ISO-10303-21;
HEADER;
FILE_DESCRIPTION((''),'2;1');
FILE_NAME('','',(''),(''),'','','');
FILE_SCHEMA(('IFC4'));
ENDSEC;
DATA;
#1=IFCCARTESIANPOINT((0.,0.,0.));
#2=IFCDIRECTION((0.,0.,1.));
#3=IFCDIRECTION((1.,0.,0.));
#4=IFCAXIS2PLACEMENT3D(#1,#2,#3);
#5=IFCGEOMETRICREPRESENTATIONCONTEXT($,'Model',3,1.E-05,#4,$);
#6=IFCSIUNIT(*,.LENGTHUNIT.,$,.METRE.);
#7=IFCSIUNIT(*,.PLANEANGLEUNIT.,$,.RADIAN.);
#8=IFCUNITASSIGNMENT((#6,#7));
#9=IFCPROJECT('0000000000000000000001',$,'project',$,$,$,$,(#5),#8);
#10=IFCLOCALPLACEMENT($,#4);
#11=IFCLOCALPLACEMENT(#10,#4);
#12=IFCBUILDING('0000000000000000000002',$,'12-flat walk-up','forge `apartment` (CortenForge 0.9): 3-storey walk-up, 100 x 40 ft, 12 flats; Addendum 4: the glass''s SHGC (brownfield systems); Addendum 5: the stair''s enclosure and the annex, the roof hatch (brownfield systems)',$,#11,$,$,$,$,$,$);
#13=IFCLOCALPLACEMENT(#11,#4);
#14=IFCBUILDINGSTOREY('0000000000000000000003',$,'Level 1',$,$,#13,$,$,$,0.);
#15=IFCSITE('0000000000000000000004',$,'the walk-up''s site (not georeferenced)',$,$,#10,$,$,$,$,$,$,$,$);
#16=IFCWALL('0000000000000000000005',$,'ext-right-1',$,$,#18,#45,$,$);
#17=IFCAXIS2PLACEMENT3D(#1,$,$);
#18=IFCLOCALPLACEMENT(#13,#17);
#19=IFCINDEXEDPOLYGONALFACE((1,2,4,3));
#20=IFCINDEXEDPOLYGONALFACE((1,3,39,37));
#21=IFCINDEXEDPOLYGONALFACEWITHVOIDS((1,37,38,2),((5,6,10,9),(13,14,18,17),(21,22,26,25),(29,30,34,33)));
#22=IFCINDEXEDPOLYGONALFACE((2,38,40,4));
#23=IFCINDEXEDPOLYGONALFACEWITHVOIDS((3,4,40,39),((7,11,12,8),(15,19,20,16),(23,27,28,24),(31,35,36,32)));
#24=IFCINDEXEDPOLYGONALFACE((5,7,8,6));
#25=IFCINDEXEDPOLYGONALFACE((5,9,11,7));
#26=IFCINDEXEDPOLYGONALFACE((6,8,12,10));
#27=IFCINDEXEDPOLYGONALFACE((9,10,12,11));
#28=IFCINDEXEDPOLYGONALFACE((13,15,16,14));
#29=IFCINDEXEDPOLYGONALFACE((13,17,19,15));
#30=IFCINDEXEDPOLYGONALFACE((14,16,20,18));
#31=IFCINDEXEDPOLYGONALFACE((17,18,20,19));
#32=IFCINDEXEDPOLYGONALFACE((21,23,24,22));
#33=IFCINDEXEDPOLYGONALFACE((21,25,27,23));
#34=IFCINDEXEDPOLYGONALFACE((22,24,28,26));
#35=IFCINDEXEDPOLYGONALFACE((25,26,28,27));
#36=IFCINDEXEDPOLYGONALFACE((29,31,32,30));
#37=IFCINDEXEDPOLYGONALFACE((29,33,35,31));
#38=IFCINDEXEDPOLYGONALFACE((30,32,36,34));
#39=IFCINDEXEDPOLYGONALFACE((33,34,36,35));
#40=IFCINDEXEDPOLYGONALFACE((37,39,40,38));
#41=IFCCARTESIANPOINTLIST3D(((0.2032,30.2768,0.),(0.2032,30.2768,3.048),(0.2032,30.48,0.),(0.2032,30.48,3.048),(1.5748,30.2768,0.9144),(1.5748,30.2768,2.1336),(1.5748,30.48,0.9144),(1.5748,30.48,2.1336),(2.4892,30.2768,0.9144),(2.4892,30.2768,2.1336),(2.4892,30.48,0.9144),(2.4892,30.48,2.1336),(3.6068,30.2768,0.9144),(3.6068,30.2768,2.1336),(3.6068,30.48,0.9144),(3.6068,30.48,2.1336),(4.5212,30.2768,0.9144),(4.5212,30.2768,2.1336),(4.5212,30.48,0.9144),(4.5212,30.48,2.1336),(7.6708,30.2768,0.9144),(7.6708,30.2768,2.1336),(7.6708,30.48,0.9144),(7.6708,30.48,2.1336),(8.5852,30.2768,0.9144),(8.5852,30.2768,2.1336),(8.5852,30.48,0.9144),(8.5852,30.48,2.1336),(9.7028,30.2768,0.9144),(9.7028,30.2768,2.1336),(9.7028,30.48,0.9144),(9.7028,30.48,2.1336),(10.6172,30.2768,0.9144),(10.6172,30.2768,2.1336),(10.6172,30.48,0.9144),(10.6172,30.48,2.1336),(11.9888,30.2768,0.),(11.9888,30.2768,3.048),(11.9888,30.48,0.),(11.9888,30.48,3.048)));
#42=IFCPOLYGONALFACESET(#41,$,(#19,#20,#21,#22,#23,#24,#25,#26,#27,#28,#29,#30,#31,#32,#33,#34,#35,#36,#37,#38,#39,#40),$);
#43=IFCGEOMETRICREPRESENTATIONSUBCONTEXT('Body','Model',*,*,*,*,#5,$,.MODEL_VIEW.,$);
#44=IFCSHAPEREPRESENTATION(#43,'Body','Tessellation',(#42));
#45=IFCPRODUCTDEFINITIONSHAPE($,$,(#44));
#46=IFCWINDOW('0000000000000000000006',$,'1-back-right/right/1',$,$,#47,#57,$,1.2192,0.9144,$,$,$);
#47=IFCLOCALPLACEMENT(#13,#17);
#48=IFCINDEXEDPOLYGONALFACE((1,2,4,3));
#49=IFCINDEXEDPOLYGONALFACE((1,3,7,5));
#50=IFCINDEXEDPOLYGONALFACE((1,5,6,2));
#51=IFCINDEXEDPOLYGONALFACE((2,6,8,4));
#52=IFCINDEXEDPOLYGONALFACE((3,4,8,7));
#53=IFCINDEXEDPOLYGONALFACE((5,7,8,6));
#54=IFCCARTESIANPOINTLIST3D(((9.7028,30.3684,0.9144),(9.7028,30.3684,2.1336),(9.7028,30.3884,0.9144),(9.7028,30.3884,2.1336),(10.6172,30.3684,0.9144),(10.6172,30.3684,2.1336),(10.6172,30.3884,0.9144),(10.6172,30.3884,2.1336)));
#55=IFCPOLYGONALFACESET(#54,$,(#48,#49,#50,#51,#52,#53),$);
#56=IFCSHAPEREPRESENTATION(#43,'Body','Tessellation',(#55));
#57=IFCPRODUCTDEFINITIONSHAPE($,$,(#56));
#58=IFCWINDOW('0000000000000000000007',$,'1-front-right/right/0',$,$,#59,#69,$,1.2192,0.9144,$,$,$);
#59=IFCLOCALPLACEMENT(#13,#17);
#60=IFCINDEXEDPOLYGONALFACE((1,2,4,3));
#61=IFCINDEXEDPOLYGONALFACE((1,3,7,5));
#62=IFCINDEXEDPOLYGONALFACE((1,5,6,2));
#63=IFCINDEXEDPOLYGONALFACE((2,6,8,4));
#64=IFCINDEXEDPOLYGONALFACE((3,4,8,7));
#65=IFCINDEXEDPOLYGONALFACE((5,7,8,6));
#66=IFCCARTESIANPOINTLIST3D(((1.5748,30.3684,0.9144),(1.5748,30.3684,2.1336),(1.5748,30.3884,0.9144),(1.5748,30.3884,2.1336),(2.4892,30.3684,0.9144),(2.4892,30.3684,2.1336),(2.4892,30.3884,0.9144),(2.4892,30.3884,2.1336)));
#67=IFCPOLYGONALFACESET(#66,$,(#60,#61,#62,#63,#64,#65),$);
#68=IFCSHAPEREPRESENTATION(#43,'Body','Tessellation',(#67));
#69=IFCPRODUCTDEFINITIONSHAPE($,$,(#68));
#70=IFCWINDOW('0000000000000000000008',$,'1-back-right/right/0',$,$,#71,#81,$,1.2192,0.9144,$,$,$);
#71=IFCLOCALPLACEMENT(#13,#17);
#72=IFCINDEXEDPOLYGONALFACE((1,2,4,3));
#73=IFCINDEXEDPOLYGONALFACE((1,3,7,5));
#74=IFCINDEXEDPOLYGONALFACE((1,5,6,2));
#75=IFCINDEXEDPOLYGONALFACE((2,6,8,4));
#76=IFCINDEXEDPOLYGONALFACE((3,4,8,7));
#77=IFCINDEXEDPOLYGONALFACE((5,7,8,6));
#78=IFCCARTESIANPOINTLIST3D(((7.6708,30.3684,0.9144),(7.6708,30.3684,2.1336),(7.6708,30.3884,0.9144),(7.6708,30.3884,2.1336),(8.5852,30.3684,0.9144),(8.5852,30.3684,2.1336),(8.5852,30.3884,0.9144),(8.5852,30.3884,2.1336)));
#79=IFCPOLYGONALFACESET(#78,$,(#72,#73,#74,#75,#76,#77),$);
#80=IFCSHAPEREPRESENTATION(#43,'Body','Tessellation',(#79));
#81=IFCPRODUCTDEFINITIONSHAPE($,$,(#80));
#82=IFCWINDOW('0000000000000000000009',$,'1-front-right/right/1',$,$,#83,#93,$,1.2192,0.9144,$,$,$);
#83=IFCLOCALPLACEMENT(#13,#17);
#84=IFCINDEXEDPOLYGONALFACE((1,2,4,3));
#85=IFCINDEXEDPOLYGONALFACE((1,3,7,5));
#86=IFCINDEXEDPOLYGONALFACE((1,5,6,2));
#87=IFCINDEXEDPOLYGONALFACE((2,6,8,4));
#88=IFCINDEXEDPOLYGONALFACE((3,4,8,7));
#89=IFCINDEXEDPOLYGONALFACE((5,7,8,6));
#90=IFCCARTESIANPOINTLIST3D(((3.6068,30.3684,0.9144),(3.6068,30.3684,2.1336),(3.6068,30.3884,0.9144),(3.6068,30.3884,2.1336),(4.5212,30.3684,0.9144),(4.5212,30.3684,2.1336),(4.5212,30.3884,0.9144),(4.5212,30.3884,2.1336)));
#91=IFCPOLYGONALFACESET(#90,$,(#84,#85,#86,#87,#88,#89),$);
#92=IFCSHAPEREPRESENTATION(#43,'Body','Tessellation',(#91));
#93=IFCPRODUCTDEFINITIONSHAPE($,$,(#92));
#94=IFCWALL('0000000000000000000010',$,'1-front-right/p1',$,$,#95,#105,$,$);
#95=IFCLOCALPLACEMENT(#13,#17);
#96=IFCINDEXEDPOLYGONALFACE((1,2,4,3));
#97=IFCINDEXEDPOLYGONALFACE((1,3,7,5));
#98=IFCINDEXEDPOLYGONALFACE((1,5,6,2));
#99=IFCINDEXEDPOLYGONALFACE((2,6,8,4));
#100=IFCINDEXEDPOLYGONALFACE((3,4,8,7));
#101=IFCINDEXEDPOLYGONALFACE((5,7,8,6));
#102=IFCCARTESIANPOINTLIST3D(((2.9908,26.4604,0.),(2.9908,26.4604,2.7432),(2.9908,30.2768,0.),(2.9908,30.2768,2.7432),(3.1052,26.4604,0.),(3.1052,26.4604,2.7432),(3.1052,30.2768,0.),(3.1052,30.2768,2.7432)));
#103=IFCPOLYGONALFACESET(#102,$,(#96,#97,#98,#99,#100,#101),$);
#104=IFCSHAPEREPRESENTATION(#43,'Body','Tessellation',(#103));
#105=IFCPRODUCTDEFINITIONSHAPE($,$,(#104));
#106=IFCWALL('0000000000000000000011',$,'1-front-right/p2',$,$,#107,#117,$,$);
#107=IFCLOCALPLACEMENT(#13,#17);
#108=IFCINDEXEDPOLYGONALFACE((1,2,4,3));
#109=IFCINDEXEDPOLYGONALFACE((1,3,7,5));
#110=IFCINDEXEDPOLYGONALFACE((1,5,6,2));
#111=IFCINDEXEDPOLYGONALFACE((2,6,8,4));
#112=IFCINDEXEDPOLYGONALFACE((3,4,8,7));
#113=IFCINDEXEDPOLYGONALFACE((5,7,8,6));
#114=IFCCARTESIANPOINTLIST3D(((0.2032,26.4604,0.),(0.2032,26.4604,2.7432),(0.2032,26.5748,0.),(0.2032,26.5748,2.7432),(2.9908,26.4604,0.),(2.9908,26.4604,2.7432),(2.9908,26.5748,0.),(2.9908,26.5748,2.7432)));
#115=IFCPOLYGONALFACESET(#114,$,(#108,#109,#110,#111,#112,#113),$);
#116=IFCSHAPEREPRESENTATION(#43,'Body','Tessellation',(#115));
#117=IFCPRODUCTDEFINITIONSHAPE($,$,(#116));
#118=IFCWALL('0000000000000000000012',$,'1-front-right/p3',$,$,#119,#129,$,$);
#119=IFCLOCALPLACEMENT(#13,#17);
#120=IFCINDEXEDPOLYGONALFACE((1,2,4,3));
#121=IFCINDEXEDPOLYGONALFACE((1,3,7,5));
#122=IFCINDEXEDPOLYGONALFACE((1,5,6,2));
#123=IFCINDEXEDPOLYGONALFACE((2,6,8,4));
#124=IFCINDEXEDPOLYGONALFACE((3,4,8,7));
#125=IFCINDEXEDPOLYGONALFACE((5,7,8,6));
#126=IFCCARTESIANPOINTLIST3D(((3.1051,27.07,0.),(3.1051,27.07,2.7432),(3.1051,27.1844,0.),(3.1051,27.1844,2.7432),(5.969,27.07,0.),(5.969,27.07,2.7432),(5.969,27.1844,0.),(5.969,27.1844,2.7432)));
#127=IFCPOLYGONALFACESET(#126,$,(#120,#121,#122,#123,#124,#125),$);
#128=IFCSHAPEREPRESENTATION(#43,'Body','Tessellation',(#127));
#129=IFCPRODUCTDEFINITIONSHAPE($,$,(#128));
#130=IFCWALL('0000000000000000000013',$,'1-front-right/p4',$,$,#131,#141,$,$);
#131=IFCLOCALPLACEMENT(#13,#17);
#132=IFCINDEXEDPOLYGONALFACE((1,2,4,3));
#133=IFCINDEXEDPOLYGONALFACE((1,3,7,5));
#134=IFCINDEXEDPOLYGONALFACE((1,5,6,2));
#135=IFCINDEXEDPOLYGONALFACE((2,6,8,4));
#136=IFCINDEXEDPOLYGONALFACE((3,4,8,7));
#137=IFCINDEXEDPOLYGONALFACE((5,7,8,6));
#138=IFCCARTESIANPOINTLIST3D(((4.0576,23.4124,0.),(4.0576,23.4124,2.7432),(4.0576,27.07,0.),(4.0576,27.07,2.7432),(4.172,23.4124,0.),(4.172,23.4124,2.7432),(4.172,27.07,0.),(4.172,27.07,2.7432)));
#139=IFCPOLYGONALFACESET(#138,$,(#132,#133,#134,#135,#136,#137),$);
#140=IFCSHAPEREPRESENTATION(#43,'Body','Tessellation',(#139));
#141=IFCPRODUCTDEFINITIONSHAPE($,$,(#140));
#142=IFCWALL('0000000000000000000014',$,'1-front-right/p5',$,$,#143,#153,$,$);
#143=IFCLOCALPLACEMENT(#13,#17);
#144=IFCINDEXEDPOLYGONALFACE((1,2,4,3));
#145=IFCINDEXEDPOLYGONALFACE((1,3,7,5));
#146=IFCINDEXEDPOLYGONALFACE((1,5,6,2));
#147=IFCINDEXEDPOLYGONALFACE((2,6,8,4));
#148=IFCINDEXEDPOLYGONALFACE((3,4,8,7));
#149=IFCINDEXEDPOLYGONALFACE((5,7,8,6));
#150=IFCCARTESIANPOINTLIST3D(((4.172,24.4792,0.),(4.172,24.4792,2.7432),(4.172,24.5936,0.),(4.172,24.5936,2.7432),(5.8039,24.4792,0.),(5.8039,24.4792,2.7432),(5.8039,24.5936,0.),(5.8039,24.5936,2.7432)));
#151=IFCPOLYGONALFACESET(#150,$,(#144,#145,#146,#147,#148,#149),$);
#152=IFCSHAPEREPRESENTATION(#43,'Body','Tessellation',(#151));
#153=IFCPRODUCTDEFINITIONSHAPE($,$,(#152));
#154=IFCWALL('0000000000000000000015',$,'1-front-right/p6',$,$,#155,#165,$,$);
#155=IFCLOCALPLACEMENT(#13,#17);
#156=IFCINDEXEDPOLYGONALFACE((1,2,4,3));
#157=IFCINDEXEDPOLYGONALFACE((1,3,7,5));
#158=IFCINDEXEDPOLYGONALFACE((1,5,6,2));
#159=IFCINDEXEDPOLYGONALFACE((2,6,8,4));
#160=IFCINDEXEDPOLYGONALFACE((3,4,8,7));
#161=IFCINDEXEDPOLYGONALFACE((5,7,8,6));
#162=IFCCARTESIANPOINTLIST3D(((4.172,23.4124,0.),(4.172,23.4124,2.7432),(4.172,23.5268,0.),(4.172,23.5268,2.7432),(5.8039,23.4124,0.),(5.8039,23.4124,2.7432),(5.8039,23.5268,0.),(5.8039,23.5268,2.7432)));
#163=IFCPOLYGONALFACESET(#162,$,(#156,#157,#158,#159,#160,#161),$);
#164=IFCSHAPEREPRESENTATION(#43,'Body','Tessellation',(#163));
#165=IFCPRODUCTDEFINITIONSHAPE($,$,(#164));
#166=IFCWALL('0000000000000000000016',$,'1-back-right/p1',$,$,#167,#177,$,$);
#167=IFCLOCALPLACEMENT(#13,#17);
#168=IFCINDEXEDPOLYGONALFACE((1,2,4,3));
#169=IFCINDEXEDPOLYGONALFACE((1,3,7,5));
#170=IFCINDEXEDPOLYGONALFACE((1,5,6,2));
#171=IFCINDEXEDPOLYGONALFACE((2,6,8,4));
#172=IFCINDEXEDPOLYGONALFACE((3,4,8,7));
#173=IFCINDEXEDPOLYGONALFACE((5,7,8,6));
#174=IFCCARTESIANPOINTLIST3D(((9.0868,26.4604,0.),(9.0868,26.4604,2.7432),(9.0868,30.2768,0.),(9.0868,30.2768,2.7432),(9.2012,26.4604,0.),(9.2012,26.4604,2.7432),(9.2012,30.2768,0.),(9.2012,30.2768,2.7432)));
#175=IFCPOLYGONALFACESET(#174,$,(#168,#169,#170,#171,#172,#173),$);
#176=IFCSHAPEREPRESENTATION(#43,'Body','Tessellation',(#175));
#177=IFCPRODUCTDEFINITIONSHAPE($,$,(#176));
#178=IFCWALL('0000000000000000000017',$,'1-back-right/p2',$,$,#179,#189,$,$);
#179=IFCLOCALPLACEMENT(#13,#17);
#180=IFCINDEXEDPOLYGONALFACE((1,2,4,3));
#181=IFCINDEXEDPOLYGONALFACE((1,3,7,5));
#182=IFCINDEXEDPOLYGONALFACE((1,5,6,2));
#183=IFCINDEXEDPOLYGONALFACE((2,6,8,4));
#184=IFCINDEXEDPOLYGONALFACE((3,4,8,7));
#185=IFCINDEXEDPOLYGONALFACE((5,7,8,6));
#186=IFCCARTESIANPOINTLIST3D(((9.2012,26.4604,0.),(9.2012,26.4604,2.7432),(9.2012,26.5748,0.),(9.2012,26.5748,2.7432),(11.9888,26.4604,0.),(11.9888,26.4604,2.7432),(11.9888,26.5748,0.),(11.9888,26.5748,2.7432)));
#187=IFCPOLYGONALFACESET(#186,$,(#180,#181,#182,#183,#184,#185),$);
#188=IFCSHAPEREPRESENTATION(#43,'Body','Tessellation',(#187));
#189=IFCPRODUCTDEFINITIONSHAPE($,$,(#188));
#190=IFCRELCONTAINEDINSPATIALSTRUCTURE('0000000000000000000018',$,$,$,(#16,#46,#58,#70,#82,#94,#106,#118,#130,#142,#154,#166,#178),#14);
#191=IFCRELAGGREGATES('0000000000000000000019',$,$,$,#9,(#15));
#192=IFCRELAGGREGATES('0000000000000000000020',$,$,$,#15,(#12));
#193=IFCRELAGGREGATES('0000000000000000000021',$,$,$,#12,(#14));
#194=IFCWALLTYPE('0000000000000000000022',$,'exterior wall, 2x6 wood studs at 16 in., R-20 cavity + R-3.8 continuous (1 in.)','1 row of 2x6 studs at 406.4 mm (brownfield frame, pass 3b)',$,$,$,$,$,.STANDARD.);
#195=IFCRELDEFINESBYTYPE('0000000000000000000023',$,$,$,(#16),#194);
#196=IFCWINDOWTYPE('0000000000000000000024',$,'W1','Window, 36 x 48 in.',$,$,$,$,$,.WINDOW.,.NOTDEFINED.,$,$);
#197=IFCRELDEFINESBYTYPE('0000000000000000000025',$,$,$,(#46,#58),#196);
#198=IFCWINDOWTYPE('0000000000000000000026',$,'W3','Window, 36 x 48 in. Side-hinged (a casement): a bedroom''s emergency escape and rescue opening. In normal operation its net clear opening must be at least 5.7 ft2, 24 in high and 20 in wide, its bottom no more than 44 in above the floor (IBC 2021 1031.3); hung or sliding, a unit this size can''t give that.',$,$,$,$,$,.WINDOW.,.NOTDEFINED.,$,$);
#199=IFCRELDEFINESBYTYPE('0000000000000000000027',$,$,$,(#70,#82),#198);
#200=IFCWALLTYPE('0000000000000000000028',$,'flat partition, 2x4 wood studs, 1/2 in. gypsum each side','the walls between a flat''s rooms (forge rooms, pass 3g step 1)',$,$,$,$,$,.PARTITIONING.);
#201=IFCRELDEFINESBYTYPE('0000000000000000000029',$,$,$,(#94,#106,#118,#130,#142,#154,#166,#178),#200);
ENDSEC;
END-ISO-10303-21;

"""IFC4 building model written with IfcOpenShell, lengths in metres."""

from ifc_helpers import new_model, si_unit, frame, frame_2d, origin, origin_with_axes, place, context, subcontext, project, spatial, rectangle, extrude, type_object, element, fill, save


model = new_model("IFC4")

# Units and contexts
model_context = context("Model", 3, precision=1e-05, world=origin_with_axes())
body_context = subcontext(model_context, "Body", "Model", "MODEL_VIEW")
ifc_project = project(units=[si_unit("LENGTHUNIT", "METRE"), si_unit("PLANEANGLEUNIT", "RADIAN")], contexts=[model_context])

# Site, building, storey
site_placement = place(None, origin_with_axes())
site = spatial("IfcSite", under=ifc_project, at=site_placement, Name="the walk-up's site (not georeferenced)")
building_placement = place(site_placement, origin_with_axes())
building = spatial("IfcBuilding", under=site, at=building_placement, Name="12-flat walk-up", Description="forge `apartment` (CortenForge 0.9): 3-storey walk-up, 100 x 40 ft, 12 flats; Addendum 4: the glass's SHGC (brownfield systems); Addendum 5: the stair's enclosure and the annex, the roof hatch (brownfield systems)")
storey_placement = place(building_placement, origin_with_axes())
storey = spatial("IfcBuildingStorey", under=building, at=storey_placement, Name="Level 1", Elevation=0.0)

# Wall, openings, windows
wall_type_1 = type_object("IfcWallType", Name="exterior wall, 2x6 wood studs at 16 in., R-20 cavity + R-3.8 continuous (1 in.)", Description="1 row of 2x6 studs at 406.4 mm (brownfield frame, pass 3b)", PredefinedType="STANDARD")
wall_1_placement = place(storey_placement, frame((0.2032, 30.2768, 0.0), z_axis=(0.0, 0.0, 1.0), x_axis=(1.0, 0.0, 0.0)))
wall_1 = element("IfcWall", 1, at=wall_1_placement, inside=storey, type_object=wall_type_1, Name="ext-right-1", context=body_context, shape_type="SweptSolid", body=[
    extrude(rectangle(XDim=11.7856, YDim=0.2032, at=frame_2d((5.8928, 0.1016))), origin(), (0.0, 0.0, 1.0), 3.048),
])
opening_1_placement = place(wall_1_placement, frame((8.382, 0.2032, 0.9144), z_axis=(0.0, 0.0, 1.0), x_axis=(-1.0, 0.0, 0.0)))
opening_1 = element("IfcOpeningElement", 2, at=opening_1_placement, cuts=wall_1, PredefinedType="OPENING", context=body_context, shape_type="SweptSolid", body=[
    extrude(rectangle(XDim=0.9144, YDim=0.2032, at=frame_2d((0.4572, 0.1016))), origin(), (0.0, 0.0, 1.0), 1.2192),
])
opening_2_placement = place(wall_1_placement, frame((10.414, 0.2032, 0.9144), z_axis=(0.0, 0.0, 1.0), x_axis=(-1.0, 0.0, 0.0)))
opening_2 = element("IfcOpeningElement", 3, at=opening_2_placement, cuts=wall_1, PredefinedType="OPENING", context=body_context, shape_type="SweptSolid", body=[
    extrude(rectangle(XDim=0.9144, YDim=0.2032, at=frame_2d((0.4572, 0.1016))), origin(), (0.0, 0.0, 1.0), 1.2192),
])
opening_3_placement = place(wall_1_placement, frame((2.286, 0.2032, 0.9144), z_axis=(0.0, 0.0, 1.0), x_axis=(-1.0, 0.0, 0.0)))
opening_3 = element("IfcOpeningElement", 4, at=opening_3_placement, cuts=wall_1, PredefinedType="OPENING", context=body_context, shape_type="SweptSolid", body=[
    extrude(rectangle(XDim=0.9144, YDim=0.2032, at=frame_2d((0.4572, 0.1016))), origin(), (0.0, 0.0, 1.0), 1.2192),
])
opening_4_placement = place(wall_1_placement, frame((4.318, 0.2032, 0.9144), z_axis=(0.0, 0.0, 1.0), x_axis=(-1.0, 0.0, 0.0)))
opening_4 = element("IfcOpeningElement", 5, at=opening_4_placement, cuts=wall_1, PredefinedType="OPENING", context=body_context, shape_type="SweptSolid", body=[
    extrude(rectangle(XDim=0.9144, YDim=0.2032, at=frame_2d((0.4572, 0.1016))), origin(), (0.0, 0.0, 1.0), 1.2192),
])
window_type_1 = type_object("IfcWindowType", Name="W1", Description="Window, 36 x 48 in.", PartitioningType="NOTDEFINED", PredefinedType="WINDOW")
window_1_placement = place(opening_2_placement, frame((0.0, 0.0916, 0.0), z_axis=(0.0, 0.0, 1.0), x_axis=(1.0, 0.0, 0.0)))
window_1 = element("IfcWindow", 6, at=window_1_placement, inside=storey, type_object=window_type_1, Name="1-back-right/right/1", OverallHeight=1.2192, OverallWidth=0.9144, context=body_context, shape_type="SweptSolid", body=[
    extrude(rectangle(XDim=0.9144, YDim=0.02, at=frame_2d((0.4572, 0.01))), origin(), (0.0, 0.0, 1.0), 1.2192),
])
fill(opening_2, window_1)
window_2_placement = place(opening_3_placement, frame((0.0, 0.0916, 0.0), z_axis=(0.0, 0.0, 1.0), x_axis=(1.0, 0.0, 0.0)))
window_2 = element("IfcWindow", 7, at=window_2_placement, inside=storey, type_object=window_type_1, Name="1-front-right/right/0", OverallHeight=1.2192, OverallWidth=0.9144, context=body_context, shape_type="SweptSolid", body=[
    extrude(rectangle(XDim=0.9144, YDim=0.02, at=frame_2d((0.4572, 0.01))), origin(), (0.0, 0.0, 1.0), 1.2192),
])
fill(opening_3, window_2)
window_type_2 = type_object("IfcWindowType", Name="W3", Description="Window, 36 x 48 in. Side-hinged (a casement): a bedroom's emergency escape and rescue opening. In normal operation its net clear opening must be at least 5.7 ft2, 24 in high and 20 in wide, its bottom no more than 44 in above the floor (IBC 2021 1031.3); hung or sliding, a unit this size can't give that.", PartitioningType="NOTDEFINED", PredefinedType="WINDOW")
window_3_placement = place(opening_1_placement, frame((0.0, 0.0916, 0.0), z_axis=(0.0, 0.0, 1.0), x_axis=(1.0, 0.0, 0.0)))
window_3 = element("IfcWindow", 8, at=window_3_placement, inside=storey, type_object=window_type_2, Name="1-back-right/right/0", OverallHeight=1.2192, OverallWidth=0.9144, context=body_context, shape_type="SweptSolid", body=[
    extrude(rectangle(XDim=0.9144, YDim=0.02, at=frame_2d((0.4572, 0.01))), origin(), (0.0, 0.0, 1.0), 1.2192),
])
fill(opening_1, window_3)
window_4_placement = place(opening_4_placement, frame((0.0, 0.0916, 0.0), z_axis=(0.0, 0.0, 1.0), x_axis=(1.0, 0.0, 0.0)))
window_4 = element("IfcWindow", 9, at=window_4_placement, inside=storey, type_object=window_type_2, Name="1-front-right/right/1", OverallHeight=1.2192, OverallWidth=0.9144, context=body_context, shape_type="SweptSolid", body=[
    extrude(rectangle(XDim=0.9144, YDim=0.02, at=frame_2d((0.4572, 0.01))), origin(), (0.0, 0.0, 1.0), 1.2192),
])
fill(opening_4, window_4)

# Walls
wall_type_2 = type_object("IfcWallType", Name="flat partition, 2x4 wood studs, 1/2 in. gypsum each side", Description="the walls between a flat's rooms (forge rooms, pass 3g step 1)", PredefinedType="PARTITIONING")
wall_2_placement = place(storey_placement, frame((2.9909, 26.4605, 0.0), z_axis=(0.0, 0.0, 1.0), x_axis=(1.0, 0.0, 0.0)))
element("IfcWall", 10, at=wall_2_placement, inside=storey, type_object=wall_type_2, Name="1-front-right/p1", context=body_context, shape_type="SweptSolid", body=[
    extrude(rectangle(XDim=0.1143, YDim=3.8163, at=frame_2d((0.0572, 1.9082))), origin(), (0.0, 0.0, 1.0), 2.7432),
])
wall_3_placement = place(storey_placement, frame((0.2032, 26.4605, 0.0), z_axis=(0.0, 0.0, 1.0), x_axis=(1.0, 0.0, 0.0)))
element("IfcWall", 11, at=wall_3_placement, inside=storey, type_object=wall_type_2, Name="1-front-right/p2", context=body_context, shape_type="SweptSolid", body=[
    extrude(rectangle(XDim=2.7877, YDim=0.1143, at=frame_2d((1.3938, 0.0572))), origin(), (0.0, 0.0, 1.0), 2.7432),
])
wall_4_placement = place(storey_placement, frame((3.1051, 27.07, 0.0), z_axis=(0.0, 0.0, 1.0), x_axis=(1.0, 0.0, 0.0)))
element("IfcWall", 12, at=wall_4_placement, inside=storey, type_object=wall_type_2, Name="1-front-right/p3", context=body_context, shape_type="SweptSolid", body=[
    extrude(rectangle(XDim=2.8639, YDim=0.1143, at=frame_2d((1.4319, 0.0572))), origin(), (0.0, 0.0, 1.0), 2.7432),
])
wall_5_placement = place(storey_placement, frame((4.0576, 23.4124, 0.0), z_axis=(0.0, 0.0, 1.0), x_axis=(1.0, 0.0, 0.0)))
element("IfcWall", 13, at=wall_5_placement, inside=storey, type_object=wall_type_2, Name="1-front-right/p4", context=body_context, shape_type="SweptSolid", body=[
    extrude(rectangle(XDim=0.1143, YDim=3.6576, at=frame_2d((0.0572, 1.8288))), origin(), (0.0, 0.0, 1.0), 2.7432),
])
for number, where, z_axis, x_axis, name in (
    (14, (4.1719, 24.4793, 0.0), (0.0, 0.0, 1.0), (1.0, 0.0, 0.0), "1-front-right/p5"),
    (15, (4.1719, 23.4124, 0.0), (0.0, 0.0, 1.0), (1.0, 0.0, 0.0), "1-front-right/p6"),
):
    element("IfcWall", number, at=place(storey_placement, frame(where, z_axis=z_axis, x_axis=x_axis)), inside=storey, type_object=wall_type_2, Name=name, context=body_context, shape_type="SweptSolid", body=[
        extrude(rectangle(XDim=1.6319, YDim=0.1143, at=frame_2d((0.816, 0.0572))), origin(), (0.0, 0.0, 1.0), 2.7432),
    ])
wall_6_placement = place(storey_placement, frame((9.0869, 26.4605, 0.0), z_axis=(0.0, 0.0, 1.0), x_axis=(1.0, 0.0, 0.0)))
element("IfcWall", 16, at=wall_6_placement, inside=storey, type_object=wall_type_2, Name="1-back-right/p1", context=body_context, shape_type="SweptSolid", body=[
    extrude(rectangle(XDim=0.1143, YDim=3.8163, at=frame_2d((0.0572, 1.9082))), origin(), (0.0, 0.0, 1.0), 2.7432),
])
wall_7_placement = place(storey_placement, frame((9.2012, 26.4605, 0.0), z_axis=(0.0, 0.0, 1.0), x_axis=(1.0, 0.0, 0.0)))
element("IfcWall", 17, at=wall_7_placement, inside=storey, type_object=wall_type_2, Name="1-back-right/p2", context=body_context, shape_type="SweptSolid", body=[
    extrude(rectangle(XDim=2.7876, YDim=0.1143, at=frame_2d((1.3938, 0.0572))), origin(), (0.0, 0.0, 1.0), 2.7432),
])

save(model, "model.ifc")
